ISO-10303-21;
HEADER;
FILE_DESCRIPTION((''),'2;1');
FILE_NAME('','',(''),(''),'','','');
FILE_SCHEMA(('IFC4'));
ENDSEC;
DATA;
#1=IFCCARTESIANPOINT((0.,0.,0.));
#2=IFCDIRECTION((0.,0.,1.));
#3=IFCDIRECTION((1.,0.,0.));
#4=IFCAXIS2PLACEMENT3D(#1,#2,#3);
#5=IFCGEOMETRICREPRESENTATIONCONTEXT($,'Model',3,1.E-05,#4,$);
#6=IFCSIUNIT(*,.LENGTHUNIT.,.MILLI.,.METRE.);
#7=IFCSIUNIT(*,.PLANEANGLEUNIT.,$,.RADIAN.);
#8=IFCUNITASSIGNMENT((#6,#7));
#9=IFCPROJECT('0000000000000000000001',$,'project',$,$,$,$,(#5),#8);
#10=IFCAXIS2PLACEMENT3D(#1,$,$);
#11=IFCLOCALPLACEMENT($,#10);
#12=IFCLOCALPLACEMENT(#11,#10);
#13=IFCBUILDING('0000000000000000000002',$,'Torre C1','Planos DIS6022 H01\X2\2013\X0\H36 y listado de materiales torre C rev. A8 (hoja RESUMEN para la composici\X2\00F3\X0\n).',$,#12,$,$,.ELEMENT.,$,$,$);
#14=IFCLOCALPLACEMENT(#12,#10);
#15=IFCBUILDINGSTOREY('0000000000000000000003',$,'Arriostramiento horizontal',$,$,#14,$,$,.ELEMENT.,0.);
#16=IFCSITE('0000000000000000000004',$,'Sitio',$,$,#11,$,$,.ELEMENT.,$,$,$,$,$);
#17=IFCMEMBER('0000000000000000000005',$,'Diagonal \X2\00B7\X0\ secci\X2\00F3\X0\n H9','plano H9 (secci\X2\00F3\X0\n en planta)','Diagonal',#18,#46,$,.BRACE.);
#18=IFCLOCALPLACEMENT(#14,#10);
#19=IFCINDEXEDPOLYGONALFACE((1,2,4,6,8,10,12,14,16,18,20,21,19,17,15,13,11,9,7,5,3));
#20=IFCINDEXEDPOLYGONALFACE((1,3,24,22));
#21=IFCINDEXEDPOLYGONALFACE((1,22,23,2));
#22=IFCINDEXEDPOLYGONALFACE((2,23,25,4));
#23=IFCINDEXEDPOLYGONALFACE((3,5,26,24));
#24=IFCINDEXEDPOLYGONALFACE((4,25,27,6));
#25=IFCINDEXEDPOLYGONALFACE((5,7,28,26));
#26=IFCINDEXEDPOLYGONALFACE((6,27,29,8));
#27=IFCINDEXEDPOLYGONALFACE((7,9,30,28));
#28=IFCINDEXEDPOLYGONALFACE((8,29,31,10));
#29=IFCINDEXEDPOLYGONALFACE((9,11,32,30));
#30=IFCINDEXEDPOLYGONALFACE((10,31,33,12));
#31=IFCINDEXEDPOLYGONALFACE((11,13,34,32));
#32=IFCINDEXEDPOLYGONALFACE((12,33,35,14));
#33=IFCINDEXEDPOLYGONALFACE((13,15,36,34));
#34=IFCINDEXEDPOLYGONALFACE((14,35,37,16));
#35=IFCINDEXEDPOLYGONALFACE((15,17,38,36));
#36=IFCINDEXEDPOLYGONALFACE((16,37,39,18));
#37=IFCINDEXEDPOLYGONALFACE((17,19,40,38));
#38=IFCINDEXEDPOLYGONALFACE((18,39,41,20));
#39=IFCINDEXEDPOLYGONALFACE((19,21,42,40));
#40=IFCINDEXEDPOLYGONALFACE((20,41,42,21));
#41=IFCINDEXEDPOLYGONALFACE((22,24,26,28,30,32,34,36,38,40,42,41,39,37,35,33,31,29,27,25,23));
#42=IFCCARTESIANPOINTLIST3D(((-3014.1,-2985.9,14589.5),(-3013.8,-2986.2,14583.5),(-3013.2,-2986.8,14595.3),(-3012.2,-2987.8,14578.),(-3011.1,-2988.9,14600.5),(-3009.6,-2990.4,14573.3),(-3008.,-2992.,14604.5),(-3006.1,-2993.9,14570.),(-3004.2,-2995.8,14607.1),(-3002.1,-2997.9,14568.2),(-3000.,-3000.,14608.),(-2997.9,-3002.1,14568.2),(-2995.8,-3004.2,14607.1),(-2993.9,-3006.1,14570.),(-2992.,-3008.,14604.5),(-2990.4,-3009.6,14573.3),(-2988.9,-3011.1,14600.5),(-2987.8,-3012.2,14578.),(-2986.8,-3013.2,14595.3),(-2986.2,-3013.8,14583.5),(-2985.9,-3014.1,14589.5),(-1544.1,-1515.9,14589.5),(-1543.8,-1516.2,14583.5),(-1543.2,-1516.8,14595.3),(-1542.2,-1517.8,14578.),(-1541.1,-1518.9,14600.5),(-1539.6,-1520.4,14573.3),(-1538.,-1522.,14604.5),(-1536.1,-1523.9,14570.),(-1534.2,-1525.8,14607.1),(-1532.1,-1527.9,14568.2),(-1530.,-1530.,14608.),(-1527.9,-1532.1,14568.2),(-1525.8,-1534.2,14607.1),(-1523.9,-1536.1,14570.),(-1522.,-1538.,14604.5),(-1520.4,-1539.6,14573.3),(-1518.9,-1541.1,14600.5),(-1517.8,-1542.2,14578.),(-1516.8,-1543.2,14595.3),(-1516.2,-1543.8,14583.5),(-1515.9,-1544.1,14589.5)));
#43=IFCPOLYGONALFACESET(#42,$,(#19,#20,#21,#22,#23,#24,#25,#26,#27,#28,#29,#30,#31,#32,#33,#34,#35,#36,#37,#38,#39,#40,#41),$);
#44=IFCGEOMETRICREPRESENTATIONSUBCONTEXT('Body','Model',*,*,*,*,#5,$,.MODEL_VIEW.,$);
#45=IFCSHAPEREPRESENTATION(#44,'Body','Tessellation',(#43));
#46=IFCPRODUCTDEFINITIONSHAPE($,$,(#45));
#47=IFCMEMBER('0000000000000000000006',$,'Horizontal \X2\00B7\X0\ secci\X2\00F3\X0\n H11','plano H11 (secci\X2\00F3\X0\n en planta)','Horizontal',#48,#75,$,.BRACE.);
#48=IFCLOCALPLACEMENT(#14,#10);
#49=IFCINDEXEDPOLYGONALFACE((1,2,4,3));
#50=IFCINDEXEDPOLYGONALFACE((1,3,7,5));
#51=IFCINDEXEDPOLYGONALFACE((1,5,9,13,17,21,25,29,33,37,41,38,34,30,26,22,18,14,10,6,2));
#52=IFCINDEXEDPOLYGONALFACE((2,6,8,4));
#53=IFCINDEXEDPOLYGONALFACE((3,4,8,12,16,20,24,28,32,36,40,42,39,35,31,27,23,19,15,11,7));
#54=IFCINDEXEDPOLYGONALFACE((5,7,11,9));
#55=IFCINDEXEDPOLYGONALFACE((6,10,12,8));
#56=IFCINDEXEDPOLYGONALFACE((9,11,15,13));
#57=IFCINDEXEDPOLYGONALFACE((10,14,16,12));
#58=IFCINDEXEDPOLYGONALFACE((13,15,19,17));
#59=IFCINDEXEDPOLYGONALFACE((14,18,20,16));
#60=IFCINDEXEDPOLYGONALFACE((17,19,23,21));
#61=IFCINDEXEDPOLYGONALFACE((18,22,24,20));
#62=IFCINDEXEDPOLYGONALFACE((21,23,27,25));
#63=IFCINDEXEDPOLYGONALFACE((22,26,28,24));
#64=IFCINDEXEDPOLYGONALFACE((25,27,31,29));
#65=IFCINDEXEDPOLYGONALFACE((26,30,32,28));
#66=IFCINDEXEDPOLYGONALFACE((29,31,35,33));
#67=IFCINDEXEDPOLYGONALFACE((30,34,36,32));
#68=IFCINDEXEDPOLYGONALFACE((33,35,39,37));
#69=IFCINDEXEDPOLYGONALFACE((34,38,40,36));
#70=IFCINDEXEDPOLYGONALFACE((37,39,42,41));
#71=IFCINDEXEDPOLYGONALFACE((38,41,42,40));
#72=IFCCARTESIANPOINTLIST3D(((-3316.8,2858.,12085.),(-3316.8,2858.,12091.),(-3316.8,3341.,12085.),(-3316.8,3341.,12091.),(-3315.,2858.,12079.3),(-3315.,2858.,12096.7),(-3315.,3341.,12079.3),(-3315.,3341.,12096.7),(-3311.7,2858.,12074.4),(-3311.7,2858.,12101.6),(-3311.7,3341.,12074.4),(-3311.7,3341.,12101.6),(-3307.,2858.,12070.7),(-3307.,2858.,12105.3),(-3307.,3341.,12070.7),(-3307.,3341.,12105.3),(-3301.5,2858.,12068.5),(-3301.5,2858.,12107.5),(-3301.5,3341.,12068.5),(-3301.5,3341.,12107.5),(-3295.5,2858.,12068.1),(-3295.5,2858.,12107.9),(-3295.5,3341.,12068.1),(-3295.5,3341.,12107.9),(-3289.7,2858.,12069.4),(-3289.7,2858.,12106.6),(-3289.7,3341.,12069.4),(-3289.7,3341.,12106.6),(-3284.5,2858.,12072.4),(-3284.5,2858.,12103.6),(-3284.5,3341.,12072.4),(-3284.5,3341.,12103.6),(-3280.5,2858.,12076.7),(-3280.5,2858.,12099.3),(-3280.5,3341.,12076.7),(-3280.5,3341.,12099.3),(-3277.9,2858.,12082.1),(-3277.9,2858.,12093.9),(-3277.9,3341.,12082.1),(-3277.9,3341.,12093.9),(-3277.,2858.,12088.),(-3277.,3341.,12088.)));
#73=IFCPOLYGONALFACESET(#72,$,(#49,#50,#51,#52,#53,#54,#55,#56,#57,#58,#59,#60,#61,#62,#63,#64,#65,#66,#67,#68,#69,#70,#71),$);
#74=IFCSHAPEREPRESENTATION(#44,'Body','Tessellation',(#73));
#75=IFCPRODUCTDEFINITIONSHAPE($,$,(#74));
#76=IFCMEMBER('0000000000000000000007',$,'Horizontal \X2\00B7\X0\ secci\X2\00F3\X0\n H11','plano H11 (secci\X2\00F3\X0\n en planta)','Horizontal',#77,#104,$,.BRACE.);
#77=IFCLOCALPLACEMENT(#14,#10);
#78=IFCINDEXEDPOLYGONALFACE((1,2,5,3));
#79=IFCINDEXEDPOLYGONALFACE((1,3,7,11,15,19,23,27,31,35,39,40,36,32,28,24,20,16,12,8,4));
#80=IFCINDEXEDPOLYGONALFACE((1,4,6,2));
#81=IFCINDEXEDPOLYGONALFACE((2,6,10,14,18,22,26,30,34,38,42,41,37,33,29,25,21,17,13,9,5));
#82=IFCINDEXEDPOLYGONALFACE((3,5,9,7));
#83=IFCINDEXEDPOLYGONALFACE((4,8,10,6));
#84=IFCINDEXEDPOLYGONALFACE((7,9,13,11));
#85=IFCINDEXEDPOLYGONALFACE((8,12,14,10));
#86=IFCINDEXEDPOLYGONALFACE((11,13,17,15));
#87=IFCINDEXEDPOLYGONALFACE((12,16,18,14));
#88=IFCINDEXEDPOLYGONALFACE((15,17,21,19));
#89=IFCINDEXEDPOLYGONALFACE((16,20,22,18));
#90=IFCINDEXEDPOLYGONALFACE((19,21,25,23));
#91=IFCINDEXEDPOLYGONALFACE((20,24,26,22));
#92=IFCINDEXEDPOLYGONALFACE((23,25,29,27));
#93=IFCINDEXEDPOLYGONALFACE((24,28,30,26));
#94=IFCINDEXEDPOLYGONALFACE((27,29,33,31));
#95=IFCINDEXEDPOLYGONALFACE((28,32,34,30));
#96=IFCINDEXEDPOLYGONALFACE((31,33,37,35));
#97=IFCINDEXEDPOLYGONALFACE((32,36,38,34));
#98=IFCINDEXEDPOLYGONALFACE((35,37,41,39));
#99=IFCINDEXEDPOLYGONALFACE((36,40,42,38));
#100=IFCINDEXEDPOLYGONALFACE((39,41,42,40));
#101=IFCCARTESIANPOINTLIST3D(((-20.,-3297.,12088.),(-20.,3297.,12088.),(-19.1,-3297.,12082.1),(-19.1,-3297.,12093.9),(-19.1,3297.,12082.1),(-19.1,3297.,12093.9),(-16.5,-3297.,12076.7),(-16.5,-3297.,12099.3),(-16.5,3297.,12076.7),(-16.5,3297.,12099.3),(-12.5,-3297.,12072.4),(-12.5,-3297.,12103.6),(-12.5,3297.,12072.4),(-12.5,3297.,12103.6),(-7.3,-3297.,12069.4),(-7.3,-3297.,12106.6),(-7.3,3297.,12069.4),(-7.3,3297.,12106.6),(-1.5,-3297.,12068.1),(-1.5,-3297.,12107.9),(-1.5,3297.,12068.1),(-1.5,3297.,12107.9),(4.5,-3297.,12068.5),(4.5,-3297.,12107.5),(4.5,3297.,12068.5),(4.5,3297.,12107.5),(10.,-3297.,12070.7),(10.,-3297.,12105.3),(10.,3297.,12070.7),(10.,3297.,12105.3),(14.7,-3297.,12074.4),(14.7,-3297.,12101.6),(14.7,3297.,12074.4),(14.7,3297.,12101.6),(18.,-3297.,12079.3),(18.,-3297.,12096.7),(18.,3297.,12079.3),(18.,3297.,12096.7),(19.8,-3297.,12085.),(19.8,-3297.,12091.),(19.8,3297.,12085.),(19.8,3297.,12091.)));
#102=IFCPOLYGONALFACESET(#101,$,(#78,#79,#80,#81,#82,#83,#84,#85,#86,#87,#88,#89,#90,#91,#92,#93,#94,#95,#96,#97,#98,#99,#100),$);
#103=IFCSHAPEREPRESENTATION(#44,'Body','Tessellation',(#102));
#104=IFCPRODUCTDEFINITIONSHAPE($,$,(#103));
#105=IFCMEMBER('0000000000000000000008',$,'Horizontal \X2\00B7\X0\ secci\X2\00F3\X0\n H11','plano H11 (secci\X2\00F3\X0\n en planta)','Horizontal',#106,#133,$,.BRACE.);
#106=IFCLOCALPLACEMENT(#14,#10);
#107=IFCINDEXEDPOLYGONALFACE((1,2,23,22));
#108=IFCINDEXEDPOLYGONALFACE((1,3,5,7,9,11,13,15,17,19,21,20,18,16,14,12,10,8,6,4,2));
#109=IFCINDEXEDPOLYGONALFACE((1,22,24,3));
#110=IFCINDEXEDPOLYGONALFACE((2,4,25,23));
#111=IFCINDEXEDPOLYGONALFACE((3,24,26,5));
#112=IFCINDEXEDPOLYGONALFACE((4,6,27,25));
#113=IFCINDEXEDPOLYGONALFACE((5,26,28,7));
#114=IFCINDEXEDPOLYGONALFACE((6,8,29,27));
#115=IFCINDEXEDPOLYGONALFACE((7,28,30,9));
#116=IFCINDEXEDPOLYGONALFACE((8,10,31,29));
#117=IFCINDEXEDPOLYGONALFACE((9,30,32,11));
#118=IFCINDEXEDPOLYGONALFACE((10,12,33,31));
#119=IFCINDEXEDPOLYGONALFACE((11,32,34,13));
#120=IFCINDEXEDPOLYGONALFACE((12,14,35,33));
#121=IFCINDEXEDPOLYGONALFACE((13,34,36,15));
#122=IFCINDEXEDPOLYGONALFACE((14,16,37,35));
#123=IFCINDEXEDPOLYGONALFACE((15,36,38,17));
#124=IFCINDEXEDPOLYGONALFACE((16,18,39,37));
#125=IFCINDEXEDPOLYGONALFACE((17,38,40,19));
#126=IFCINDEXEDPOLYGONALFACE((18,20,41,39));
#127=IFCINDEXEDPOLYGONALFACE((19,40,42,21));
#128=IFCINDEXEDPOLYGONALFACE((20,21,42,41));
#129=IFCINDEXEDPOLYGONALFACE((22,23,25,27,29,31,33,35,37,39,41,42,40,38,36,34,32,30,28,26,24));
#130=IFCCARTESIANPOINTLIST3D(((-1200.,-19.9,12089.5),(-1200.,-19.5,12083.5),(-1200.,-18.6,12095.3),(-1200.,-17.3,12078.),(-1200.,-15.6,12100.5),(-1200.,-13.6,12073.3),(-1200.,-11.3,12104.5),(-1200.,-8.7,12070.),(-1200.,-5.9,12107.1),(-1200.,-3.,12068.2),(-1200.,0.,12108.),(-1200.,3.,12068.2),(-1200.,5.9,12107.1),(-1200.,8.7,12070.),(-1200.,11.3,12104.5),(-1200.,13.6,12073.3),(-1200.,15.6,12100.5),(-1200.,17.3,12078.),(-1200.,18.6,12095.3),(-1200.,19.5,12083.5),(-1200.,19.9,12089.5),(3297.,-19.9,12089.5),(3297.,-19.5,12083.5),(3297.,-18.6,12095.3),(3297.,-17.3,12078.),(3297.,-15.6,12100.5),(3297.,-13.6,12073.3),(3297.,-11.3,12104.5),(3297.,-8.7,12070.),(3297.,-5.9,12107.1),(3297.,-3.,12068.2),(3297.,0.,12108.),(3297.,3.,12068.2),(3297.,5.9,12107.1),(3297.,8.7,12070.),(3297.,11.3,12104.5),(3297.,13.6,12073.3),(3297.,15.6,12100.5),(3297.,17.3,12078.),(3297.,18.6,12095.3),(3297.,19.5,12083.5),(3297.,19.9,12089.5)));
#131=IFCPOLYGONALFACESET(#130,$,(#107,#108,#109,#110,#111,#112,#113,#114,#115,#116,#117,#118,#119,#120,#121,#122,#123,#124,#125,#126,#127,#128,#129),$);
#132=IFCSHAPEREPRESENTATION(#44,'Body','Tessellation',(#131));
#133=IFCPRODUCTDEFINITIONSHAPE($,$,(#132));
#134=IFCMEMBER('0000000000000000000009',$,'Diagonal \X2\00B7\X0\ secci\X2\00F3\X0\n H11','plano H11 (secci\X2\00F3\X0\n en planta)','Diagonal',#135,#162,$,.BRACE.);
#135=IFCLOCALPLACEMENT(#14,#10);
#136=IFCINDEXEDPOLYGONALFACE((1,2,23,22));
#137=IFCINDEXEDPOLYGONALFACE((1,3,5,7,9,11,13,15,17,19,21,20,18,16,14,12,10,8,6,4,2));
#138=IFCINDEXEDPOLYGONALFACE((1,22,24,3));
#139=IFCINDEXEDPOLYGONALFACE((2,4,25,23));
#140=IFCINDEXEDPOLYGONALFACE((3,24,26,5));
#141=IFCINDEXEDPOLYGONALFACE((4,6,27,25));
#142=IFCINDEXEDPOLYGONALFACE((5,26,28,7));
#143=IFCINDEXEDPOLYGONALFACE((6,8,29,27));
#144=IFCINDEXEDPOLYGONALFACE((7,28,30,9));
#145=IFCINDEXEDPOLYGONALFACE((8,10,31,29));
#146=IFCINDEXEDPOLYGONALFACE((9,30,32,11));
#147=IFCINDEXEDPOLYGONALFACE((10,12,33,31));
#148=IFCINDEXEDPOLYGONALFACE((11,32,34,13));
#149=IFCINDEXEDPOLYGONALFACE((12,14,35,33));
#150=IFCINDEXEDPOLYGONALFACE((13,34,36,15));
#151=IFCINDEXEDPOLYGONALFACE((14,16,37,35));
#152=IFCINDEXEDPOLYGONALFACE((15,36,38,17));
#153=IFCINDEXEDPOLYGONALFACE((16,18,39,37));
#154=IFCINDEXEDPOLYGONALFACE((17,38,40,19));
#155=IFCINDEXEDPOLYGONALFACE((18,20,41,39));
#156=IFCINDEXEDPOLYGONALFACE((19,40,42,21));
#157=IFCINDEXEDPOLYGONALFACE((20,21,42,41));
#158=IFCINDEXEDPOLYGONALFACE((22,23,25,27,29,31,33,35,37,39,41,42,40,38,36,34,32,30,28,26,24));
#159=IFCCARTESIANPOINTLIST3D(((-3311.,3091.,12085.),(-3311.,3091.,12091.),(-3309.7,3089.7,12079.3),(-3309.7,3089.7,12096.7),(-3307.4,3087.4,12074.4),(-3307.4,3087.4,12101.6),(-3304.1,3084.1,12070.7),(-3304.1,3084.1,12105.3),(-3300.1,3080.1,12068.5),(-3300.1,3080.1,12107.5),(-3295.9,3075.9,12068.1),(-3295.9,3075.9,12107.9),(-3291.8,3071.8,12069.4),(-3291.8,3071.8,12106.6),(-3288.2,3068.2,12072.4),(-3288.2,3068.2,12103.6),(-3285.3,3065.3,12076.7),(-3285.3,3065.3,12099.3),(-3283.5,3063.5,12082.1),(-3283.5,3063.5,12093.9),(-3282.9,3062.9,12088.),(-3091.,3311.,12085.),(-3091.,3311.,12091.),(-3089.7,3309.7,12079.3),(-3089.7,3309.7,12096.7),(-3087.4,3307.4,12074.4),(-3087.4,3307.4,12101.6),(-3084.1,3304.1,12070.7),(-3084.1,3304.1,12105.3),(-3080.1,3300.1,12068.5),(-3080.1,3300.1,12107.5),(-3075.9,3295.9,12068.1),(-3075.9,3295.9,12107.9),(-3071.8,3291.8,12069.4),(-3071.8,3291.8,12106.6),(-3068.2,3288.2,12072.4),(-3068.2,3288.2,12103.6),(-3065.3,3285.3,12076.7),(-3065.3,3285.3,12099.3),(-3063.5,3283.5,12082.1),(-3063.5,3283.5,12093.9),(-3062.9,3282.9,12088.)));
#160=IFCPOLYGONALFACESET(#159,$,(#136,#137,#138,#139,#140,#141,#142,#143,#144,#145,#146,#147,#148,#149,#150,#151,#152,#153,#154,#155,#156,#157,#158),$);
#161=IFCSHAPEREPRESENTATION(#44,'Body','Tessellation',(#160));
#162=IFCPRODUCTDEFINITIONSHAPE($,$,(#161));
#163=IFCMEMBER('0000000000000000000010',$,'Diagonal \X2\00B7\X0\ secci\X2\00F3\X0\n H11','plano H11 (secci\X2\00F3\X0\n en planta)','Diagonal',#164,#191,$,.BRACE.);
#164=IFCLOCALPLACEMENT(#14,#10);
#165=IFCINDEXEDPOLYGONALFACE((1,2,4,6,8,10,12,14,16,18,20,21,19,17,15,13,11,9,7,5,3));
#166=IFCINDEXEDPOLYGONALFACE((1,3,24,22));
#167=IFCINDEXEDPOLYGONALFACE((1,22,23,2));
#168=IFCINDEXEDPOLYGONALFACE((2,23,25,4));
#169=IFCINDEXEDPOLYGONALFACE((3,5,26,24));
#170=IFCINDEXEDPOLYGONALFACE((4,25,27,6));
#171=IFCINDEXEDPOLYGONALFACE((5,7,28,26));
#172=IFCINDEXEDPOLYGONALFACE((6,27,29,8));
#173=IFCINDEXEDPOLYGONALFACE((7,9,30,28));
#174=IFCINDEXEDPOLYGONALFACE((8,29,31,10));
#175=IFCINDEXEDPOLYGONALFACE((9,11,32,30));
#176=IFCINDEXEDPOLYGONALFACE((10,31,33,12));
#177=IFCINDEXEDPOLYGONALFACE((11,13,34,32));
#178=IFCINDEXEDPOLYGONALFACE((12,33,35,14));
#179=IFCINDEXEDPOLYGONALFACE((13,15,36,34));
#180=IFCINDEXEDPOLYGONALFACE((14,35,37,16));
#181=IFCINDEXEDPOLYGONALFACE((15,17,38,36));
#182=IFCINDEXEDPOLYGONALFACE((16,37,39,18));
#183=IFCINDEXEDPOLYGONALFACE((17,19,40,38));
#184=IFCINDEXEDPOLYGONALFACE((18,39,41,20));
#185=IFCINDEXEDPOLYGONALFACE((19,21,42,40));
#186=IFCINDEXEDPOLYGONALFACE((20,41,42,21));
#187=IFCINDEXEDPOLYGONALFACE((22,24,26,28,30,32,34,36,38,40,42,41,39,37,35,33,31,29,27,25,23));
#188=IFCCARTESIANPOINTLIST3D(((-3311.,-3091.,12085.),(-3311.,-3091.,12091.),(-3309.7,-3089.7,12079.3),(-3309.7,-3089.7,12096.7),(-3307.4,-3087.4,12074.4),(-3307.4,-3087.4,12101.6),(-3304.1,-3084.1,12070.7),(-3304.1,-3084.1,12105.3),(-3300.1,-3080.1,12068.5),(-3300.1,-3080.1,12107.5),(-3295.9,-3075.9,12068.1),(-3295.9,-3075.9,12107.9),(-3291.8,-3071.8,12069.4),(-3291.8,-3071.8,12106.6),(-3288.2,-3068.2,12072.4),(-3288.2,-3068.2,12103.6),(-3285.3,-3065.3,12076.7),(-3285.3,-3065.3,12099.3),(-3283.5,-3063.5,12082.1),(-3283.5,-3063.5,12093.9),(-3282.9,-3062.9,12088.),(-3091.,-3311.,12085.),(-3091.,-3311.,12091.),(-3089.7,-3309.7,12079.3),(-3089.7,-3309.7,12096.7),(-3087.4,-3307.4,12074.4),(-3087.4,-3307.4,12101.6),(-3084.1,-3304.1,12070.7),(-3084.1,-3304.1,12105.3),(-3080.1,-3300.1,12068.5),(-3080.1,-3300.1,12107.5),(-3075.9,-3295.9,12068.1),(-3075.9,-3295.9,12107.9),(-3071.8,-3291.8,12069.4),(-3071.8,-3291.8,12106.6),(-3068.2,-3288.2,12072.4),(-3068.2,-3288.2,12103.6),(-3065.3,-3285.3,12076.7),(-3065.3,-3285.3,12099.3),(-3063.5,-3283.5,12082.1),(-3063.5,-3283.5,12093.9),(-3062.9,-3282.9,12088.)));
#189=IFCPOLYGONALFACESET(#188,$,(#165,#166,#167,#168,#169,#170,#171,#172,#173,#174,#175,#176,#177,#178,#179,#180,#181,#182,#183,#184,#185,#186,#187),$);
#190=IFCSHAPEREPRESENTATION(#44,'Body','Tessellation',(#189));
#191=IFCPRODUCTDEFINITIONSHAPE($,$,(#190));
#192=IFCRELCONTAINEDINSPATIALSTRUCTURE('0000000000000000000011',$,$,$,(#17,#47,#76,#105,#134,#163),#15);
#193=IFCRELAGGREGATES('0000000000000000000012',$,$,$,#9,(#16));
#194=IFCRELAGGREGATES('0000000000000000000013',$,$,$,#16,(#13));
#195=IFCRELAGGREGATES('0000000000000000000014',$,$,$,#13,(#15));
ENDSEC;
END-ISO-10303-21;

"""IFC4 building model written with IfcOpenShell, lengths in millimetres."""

from ifc_helpers import new_model, si_unit, frame, origin, origin_with_axes, place, context, subcontext, project, spatial, circle, extrude, element, save


model = new_model("IFC4")

# Units and contexts
model_context = context("Model", 3, precision=1e-05, world=origin_with_axes())
body_context = subcontext(model_context, "Body", "Model", "MODEL_VIEW")
ifc_project = project(units=[si_unit("LENGTHUNIT", "METRE", prefix="MILLI"), si_unit("PLANEANGLEUNIT", "RADIAN")], contexts=[model_context])

# Site, building, storey
site_placement = place(None, origin())
site = spatial("IfcSite", under=ifc_project, at=site_placement, Name="Sitio", CompositionType="ELEMENT")
building_placement = place(site_placement, origin())
building = spatial("IfcBuilding", under=site, at=building_placement, Name="Torre C1", Description="Planos DIS6022 H01–H36 y listado de materiales torre C rev. A8 (hoja RESUMEN para la composición).", CompositionType="ELEMENT")
storey_placement = place(building_placement, origin())
storey = spatial("IfcBuildingStorey", under=building, at=storey_placement, Name="Arriostramiento horizontal", CompositionType="ELEMENT", Elevation=0.0)

# Members
for number, where, z_axis, x_axis, name in (
    (1, (-3000.0, -3000.0, 14588.0), (0.707107, 0.707107, 0.0), (0.0, 0.0, 1.0), "Diagonal · sección H9"),
):
    element("IfcMember", number, at=place(storey_placement, frame(where, z_axis=z_axis, x_axis=x_axis)), inside=storey, Name=name, Description="plano H9 (sección en planta)", ObjectType="Diagonal", PredefinedType="BRACE", context=body_context, shape_type="SweptSolid", body=[
        extrude(circle(Radius=20.0), None, (0.0, 0.0, 1.0), 2078.9),
    ])
member_1_placement = place(storey_placement, frame((-3297.0, 3341.0, 12088.0), z_axis=(0.0, -1.0, 0.0), x_axis=(1.0, 0.0, 0.0)))
element("IfcMember", 2, at=member_1_placement, inside=storey, Name="Horizontal · sección H11", Description="plano H11 (sección en planta)", ObjectType="Horizontal", PredefinedType="BRACE", context=body_context, shape_type="SweptSolid", body=[
    extrude(circle(Radius=20.0), None, (0.0, 0.0, 1.0), 483.0),
])
member_2_placement = place(storey_placement, frame((0.0, 3297.0, 12088.0), z_axis=(0.0, -1.0, 0.0), x_axis=(-1.0, 0.0, 0.0)))
element("IfcMember", 3, at=member_2_placement, inside=storey, Name="Horizontal · sección H11", Description="plano H11 (sección en planta)", ObjectType="Horizontal", PredefinedType="BRACE", context=body_context, shape_type="SweptSolid", body=[
    extrude(circle(Radius=20.0), None, (0.0, 0.0, 1.0), 6594.0),
])
member_3_placement = place(storey_placement, frame((-1200.0, 0.0, 12088.0), z_axis=(1.0, 0.0, 0.0), x_axis=(0.0, 0.0, 1.0)))
element("IfcMember", 4, at=member_3_placement, inside=storey, Name="Horizontal · sección H11", Description="plano H11 (sección en planta)", ObjectType="Horizontal", PredefinedType="BRACE", context=body_context, shape_type="SweptSolid", body=[
    extrude(circle(Radius=20.0), None, (0.0, 0.0, 1.0), 4497.0),
])
for number, where, z_axis, x_axis, name in (
    (5, (-3077.0, 3297.0, 12088.0), (-0.707107, -0.707107, 0.0), (0.707107, -0.707107, 0.0), "Diagonal · sección H11"),
    (6, (-3297.0, -3077.0, 12088.0), (0.707107, -0.707107, 0.0), (0.707107, 0.707107, 0.0), "Diagonal · sección H11"),
):
    element("IfcMember", number, at=place(storey_placement, frame(where, z_axis=z_axis, x_axis=x_axis)), inside=storey, Name=name, Description="plano H11 (sección en planta)", ObjectType="Diagonal", PredefinedType="BRACE", context=body_context, shape_type="SweptSolid", body=[
        extrude(circle(Radius=20.0), None, (0.0, 0.0, 1.0), 311.1),
    ])

save(model, "model.ifc")
